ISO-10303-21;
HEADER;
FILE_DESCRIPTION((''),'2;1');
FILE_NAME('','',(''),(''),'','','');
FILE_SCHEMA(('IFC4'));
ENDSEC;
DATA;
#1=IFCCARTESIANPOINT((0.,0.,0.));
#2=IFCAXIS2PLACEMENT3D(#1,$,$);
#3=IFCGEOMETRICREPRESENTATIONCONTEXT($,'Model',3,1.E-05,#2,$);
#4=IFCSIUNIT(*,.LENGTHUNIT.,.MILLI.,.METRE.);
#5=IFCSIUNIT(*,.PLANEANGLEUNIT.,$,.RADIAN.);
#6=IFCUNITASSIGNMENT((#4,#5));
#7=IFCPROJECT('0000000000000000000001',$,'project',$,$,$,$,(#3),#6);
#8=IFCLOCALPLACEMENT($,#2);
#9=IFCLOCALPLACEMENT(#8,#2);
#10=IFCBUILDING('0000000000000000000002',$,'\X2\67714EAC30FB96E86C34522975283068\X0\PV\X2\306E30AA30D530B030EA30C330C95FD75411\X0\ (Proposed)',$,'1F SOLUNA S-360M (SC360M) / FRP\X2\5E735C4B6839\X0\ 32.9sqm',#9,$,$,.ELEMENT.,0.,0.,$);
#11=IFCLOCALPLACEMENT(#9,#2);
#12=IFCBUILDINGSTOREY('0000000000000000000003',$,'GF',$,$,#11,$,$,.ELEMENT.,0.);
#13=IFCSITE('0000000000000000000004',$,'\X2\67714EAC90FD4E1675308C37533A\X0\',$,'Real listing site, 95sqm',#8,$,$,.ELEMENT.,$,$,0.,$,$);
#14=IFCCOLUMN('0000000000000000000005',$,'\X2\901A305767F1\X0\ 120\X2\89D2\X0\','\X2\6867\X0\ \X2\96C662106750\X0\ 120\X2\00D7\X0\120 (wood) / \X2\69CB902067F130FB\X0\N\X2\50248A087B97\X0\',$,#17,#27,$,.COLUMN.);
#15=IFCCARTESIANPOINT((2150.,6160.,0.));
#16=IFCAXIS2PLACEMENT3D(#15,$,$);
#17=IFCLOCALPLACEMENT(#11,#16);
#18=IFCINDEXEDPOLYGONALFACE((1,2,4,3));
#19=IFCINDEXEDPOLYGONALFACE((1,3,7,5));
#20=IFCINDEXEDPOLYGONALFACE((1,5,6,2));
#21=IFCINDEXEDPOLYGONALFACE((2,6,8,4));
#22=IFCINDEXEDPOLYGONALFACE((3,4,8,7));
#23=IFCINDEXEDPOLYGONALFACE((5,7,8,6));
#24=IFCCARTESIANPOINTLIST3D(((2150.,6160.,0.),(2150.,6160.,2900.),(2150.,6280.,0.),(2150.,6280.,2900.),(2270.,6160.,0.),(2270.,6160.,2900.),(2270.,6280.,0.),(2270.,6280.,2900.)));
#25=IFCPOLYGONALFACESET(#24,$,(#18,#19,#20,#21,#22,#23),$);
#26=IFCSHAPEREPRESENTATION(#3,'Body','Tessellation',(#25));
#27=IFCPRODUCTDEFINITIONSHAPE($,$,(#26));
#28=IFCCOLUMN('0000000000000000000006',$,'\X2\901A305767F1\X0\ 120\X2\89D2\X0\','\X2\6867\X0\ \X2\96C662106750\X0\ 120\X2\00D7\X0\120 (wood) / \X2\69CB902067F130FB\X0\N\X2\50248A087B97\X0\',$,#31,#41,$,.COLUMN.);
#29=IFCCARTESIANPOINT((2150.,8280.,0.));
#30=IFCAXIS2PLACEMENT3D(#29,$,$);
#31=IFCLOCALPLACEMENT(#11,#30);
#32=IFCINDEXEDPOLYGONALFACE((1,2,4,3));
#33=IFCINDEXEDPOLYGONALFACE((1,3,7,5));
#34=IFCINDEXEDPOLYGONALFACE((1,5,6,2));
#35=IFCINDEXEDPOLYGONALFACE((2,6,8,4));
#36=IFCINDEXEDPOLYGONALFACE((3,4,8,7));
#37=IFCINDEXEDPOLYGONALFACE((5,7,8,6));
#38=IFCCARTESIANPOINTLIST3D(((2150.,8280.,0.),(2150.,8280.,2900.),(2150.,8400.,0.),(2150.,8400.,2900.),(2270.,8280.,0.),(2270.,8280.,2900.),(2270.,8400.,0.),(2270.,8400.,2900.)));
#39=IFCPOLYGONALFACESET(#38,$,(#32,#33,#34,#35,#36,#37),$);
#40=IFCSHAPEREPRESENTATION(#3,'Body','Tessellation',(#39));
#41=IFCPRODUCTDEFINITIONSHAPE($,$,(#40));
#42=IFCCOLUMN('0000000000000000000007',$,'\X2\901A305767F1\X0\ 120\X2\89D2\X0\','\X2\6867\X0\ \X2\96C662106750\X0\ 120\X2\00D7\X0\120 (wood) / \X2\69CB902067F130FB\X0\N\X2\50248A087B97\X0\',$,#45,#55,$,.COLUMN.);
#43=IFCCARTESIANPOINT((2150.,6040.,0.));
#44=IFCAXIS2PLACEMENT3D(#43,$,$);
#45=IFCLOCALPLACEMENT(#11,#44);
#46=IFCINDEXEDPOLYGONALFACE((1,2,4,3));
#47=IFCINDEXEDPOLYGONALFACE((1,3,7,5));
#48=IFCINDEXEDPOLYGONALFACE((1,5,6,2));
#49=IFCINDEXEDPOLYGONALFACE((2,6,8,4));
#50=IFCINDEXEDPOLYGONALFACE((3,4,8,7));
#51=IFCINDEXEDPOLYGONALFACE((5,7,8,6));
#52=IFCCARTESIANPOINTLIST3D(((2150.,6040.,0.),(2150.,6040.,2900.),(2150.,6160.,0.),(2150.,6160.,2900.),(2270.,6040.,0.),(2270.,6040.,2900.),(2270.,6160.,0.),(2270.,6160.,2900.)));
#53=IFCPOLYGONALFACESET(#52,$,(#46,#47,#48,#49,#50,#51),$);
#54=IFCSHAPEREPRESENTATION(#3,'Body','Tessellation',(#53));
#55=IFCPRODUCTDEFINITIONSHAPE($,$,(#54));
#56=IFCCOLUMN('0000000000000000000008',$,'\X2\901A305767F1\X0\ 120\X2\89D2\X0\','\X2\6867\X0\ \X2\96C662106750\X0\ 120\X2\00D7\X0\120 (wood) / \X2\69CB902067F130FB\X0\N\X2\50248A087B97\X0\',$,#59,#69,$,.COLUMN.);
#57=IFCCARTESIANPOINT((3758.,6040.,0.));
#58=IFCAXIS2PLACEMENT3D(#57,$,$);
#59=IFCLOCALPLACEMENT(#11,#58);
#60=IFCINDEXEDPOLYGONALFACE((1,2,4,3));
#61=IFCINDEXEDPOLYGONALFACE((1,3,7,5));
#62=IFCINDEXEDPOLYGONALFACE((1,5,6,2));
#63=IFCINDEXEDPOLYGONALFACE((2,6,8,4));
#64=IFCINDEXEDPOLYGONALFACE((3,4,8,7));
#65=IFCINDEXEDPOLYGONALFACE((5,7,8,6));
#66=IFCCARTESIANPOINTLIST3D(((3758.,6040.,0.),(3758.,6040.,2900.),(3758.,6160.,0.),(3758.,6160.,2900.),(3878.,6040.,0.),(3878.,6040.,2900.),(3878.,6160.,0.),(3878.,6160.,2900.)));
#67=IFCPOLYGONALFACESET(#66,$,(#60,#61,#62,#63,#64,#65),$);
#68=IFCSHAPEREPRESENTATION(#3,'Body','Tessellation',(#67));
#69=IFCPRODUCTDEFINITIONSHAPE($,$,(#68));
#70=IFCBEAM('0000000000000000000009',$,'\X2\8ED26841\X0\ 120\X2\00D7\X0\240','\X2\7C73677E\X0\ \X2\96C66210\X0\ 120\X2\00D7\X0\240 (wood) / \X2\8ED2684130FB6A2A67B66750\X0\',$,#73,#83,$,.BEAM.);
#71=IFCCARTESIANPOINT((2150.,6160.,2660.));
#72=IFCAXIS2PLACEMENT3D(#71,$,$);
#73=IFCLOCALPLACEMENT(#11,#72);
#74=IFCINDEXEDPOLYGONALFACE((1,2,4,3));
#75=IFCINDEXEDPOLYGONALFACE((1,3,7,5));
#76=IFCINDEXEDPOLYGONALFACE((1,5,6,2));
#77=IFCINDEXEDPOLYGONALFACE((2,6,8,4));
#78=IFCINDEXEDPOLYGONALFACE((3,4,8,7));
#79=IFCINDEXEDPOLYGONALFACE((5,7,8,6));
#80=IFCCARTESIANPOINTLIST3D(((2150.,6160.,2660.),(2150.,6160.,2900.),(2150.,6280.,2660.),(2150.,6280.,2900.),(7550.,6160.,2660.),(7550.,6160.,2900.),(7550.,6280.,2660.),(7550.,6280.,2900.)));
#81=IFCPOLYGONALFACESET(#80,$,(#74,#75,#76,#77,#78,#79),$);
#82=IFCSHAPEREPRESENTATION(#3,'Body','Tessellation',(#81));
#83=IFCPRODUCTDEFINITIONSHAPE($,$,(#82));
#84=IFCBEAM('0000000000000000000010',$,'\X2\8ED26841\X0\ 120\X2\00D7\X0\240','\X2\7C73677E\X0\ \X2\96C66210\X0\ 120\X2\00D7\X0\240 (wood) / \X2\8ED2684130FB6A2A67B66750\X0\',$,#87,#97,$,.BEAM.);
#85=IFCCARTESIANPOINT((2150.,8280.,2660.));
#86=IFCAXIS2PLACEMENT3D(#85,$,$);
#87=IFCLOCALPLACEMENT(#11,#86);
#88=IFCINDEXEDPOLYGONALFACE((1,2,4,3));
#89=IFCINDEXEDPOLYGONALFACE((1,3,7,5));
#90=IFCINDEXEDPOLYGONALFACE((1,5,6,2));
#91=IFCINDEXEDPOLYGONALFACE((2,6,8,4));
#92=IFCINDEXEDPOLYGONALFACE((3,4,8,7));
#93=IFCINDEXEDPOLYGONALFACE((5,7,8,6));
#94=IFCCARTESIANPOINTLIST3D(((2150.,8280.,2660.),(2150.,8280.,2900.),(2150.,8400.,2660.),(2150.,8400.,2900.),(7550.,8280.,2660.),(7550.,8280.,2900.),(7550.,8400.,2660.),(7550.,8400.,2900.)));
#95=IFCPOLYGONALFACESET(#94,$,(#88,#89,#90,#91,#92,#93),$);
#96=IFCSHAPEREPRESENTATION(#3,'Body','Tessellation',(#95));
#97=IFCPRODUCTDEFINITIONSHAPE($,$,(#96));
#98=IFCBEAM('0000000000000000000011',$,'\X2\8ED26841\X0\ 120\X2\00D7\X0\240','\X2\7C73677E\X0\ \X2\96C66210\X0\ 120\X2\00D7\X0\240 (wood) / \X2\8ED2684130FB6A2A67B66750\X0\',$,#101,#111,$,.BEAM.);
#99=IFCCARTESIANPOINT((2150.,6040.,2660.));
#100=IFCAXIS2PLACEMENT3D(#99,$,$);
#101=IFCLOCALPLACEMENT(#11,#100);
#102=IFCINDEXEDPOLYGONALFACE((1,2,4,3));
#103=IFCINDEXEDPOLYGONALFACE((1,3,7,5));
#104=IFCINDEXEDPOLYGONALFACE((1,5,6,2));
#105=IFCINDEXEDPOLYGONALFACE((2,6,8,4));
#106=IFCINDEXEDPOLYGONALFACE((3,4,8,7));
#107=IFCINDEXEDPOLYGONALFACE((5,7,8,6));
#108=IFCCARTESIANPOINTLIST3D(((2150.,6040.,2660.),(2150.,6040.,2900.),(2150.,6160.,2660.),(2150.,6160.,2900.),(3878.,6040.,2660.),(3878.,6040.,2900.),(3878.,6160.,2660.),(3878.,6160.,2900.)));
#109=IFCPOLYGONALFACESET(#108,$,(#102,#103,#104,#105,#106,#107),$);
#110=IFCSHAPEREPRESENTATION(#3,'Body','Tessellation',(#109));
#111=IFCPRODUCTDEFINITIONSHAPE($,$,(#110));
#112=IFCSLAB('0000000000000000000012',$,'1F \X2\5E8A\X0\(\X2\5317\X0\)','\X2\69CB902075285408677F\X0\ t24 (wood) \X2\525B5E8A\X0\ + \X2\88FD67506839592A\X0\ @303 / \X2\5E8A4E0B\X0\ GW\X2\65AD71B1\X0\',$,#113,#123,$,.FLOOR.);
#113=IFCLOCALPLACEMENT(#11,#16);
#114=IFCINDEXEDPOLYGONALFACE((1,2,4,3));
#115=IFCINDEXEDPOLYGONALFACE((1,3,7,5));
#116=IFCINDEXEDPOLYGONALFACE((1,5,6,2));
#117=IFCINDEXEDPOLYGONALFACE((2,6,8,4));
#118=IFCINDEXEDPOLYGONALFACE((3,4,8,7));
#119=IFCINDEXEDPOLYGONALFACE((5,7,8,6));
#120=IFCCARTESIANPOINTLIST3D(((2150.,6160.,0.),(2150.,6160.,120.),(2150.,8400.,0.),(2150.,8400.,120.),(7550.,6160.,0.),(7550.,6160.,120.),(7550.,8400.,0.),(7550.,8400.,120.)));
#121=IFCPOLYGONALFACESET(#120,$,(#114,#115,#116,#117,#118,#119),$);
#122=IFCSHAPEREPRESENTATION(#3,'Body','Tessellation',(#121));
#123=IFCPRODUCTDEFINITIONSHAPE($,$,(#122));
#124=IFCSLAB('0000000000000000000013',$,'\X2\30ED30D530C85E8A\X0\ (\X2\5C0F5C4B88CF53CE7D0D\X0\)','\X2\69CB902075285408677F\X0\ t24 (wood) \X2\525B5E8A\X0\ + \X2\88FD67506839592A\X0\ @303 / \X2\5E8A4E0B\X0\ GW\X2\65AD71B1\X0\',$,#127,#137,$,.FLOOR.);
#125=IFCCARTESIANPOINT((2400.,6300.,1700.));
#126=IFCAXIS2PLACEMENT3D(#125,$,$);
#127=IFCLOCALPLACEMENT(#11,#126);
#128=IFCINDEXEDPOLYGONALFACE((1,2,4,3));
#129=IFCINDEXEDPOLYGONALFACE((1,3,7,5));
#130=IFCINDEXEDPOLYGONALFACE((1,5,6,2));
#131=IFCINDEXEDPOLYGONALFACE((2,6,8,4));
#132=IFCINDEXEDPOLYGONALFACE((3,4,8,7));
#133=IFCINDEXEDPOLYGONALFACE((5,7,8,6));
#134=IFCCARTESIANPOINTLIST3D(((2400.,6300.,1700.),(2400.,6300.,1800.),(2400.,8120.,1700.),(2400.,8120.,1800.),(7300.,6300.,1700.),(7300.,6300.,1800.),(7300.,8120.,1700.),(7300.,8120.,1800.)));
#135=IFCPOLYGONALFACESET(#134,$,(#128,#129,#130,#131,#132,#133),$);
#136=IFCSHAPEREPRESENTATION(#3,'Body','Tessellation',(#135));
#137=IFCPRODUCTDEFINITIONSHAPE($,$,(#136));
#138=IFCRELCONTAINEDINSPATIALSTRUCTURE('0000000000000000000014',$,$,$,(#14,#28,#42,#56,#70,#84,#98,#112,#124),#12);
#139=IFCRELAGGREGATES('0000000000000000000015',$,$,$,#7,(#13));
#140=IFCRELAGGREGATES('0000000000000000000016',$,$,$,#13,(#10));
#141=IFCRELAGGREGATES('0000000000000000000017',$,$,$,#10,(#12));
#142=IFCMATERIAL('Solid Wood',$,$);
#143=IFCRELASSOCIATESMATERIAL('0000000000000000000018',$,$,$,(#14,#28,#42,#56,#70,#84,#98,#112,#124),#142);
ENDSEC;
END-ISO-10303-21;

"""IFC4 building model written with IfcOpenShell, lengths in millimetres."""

from ifc_helpers import new_model, si_unit, frame, frame_2d, origin, place, context, project, spatial, rectangle, extrude, material, element, save


model = new_model("IFC4")

# Units and contexts
model_context = context("Model", 3, precision=1e-05, world=origin())
ifc_project = project(units=[si_unit("LENGTHUNIT", "METRE", prefix="MILLI"), si_unit("PLANEANGLEUNIT", "RADIAN")], contexts=[model_context])

# Site, building, storey
site_placement = place(None, origin())
site = spatial("IfcSite", under=ifc_project, at=site_placement, Name="東京都世田谷区", ObjectType="Real listing site, 95sqm", CompositionType="ELEMENT", RefElevation=0.0)
building_placement = place(site_placement, origin())
building = spatial("IfcBuilding", under=site, at=building_placement, Name="東京・雨水利用とPVのオフグリッド志向 (Proposed)", ObjectType="1F SOLUNA S-360M (SC360M) / FRP平屋根 32.9sqm", CompositionType="ELEMENT", ElevationOfRefHeight=0.0, ElevationOfTerrain=0.0)
storey_placement = place(building_placement, origin())
storey = spatial("IfcBuildingStorey", under=building, at=storey_placement, Name="GF", CompositionType="ELEMENT", Elevation=0.0)

# Columns
ifc_material_1 = material(Name="Solid Wood")
column_1_placement = place(storey_placement, frame((2150.0, 6160.0, 0.0)))
element("IfcColumn", 1, at=column_1_placement, inside=storey, material=ifc_material_1, Name="通し柱 120角", Description="桧 集成材 120×120 (wood) / 構造柱・N値計算", PredefinedType="COLUMN", context=model_context, shape_type="SweptSolid", body=[
    extrude(rectangle(XDim=120.0, YDim=120.0, at=frame_2d((60.0, 60.0))), frame((2150.0, 6160.0, 0.0)), (0.0, 0.0, 1.0), 2900.0),
])
column_2_placement = place(storey_placement, frame((2150.0, 8280.0, 0.0)))
element("IfcColumn", 2, at=column_2_placement, inside=storey, material=ifc_material_1, Name="通し柱 120角", Description="桧 集成材 120×120 (wood) / 構造柱・N値計算", PredefinedType="COLUMN", context=model_context, shape_type="SweptSolid", body=[
    extrude(rectangle(XDim=120.0, YDim=120.0, at=frame_2d((60.0, 60.0))), frame((2150.0, 8280.0, 0.0)), (0.0, 0.0, 1.0), 2900.0),
])
column_3_placement = place(storey_placement, frame((2150.0, 6040.0, 0.0)))
element("IfcColumn", 3, at=column_3_placement, inside=storey, material=ifc_material_1, Name="通し柱 120角", Description="桧 集成材 120×120 (wood) / 構造柱・N値計算", PredefinedType="COLUMN", context=model_context, shape_type="SweptSolid", body=[
    extrude(rectangle(XDim=120.0, YDim=120.0, at=frame_2d((60.0, 60.0))), frame((2150.0, 6040.0, 0.0)), (0.0, 0.0, 1.0), 2900.0),
])
column_4_placement = place(storey_placement, frame((3758.0, 6040.0, 0.0)))
element("IfcColumn", 4, at=column_4_placement, inside=storey, material=ifc_material_1, Name="通し柱 120角", Description="桧 集成材 120×120 (wood) / 構造柱・N値計算", PredefinedType="COLUMN", context=model_context, shape_type="SweptSolid", body=[
    extrude(rectangle(XDim=120.0, YDim=120.0, at=frame_2d((60.0, 60.0))), frame((3758.0, 6040.0, 0.0)), (0.0, 0.0, 1.0), 2900.0),
])

# Beams
beam_1_placement = place(storey_placement, frame((2150.0, 6160.0, 2660.0)))
element("IfcBeam", 5, at=beam_1_placement, inside=storey, material=ifc_material_1, Name="軒桁 120×240", Description="米松 集成 120×240 (wood) / 軒桁・横架材", PredefinedType="BEAM", context=model_context, shape_type="SweptSolid", body=[
    extrude(rectangle(XDim=5400.0, YDim=120.0, at=frame_2d((2700.0, 60.0))), frame((2150.0, 6160.0, 2660.0)), (0.0, 0.0, 1.0), 240.0),
])
beam_2_placement = place(storey_placement, frame((2150.0, 8280.0, 2660.0)))
element("IfcBeam", 6, at=beam_2_placement, inside=storey, material=ifc_material_1, Name="軒桁 120×240", Description="米松 集成 120×240 (wood) / 軒桁・横架材", PredefinedType="BEAM", context=model_context, shape_type="SweptSolid", body=[
    extrude(rectangle(XDim=5400.0, YDim=120.0, at=frame_2d((2700.0, 60.0))), frame((2150.0, 8280.0, 2660.0)), (0.0, 0.0, 1.0), 240.0),
])
beam_3_placement = place(storey_placement, frame((2150.0, 6040.0, 2660.0)))
element("IfcBeam", 7, at=beam_3_placement, inside=storey, material=ifc_material_1, Name="軒桁 120×240", Description="米松 集成 120×240 (wood) / 軒桁・横架材", PredefinedType="BEAM", context=model_context, shape_type="SweptSolid", body=[
    extrude(rectangle(XDim=1728.0, YDim=120.0, at=frame_2d((864.0, 60.0))), frame((2150.0, 6040.0, 2660.0)), (0.0, 0.0, 1.0), 240.0),
])

# Slabs
slab_1_placement = place(storey_placement, frame((2150.0, 6160.0, 0.0)))
element("IfcSlab", 8, at=slab_1_placement, inside=storey, material=ifc_material_1, Name="1F 床(北)", Description="構造用合板 t24 (wood) 剛床 + 製材根太 @303 / 床下 GW断熱", PredefinedType="FLOOR", context=model_context, shape_type="SweptSolid", body=[
    extrude(rectangle(XDim=5400.0, YDim=2240.0, at=frame_2d((2700.0, 1120.0))), frame((2150.0, 6160.0, 0.0)), (0.0, 0.0, 1.0), 120.0),
])
slab_2_placement = place(storey_placement, frame((2400.0, 6300.0, 1700.0)))
element("IfcSlab", 9, at=slab_2_placement, inside=storey, material=ifc_material_1, Name="ロフト床 (小屋裏収納)", Description="構造用合板 t24 (wood) 剛床 + 製材根太 @303 / 床下 GW断熱", PredefinedType="FLOOR", context=model_context, shape_type="SweptSolid", body=[
    extrude(rectangle(XDim=4900.0, YDim=1820.0, at=frame_2d((2450.0, 910.0))), frame((2400.0, 6300.0, 1700.0)), (0.0, 0.0, 1.0), 100.0),
])

save(model, "model.ifc")
